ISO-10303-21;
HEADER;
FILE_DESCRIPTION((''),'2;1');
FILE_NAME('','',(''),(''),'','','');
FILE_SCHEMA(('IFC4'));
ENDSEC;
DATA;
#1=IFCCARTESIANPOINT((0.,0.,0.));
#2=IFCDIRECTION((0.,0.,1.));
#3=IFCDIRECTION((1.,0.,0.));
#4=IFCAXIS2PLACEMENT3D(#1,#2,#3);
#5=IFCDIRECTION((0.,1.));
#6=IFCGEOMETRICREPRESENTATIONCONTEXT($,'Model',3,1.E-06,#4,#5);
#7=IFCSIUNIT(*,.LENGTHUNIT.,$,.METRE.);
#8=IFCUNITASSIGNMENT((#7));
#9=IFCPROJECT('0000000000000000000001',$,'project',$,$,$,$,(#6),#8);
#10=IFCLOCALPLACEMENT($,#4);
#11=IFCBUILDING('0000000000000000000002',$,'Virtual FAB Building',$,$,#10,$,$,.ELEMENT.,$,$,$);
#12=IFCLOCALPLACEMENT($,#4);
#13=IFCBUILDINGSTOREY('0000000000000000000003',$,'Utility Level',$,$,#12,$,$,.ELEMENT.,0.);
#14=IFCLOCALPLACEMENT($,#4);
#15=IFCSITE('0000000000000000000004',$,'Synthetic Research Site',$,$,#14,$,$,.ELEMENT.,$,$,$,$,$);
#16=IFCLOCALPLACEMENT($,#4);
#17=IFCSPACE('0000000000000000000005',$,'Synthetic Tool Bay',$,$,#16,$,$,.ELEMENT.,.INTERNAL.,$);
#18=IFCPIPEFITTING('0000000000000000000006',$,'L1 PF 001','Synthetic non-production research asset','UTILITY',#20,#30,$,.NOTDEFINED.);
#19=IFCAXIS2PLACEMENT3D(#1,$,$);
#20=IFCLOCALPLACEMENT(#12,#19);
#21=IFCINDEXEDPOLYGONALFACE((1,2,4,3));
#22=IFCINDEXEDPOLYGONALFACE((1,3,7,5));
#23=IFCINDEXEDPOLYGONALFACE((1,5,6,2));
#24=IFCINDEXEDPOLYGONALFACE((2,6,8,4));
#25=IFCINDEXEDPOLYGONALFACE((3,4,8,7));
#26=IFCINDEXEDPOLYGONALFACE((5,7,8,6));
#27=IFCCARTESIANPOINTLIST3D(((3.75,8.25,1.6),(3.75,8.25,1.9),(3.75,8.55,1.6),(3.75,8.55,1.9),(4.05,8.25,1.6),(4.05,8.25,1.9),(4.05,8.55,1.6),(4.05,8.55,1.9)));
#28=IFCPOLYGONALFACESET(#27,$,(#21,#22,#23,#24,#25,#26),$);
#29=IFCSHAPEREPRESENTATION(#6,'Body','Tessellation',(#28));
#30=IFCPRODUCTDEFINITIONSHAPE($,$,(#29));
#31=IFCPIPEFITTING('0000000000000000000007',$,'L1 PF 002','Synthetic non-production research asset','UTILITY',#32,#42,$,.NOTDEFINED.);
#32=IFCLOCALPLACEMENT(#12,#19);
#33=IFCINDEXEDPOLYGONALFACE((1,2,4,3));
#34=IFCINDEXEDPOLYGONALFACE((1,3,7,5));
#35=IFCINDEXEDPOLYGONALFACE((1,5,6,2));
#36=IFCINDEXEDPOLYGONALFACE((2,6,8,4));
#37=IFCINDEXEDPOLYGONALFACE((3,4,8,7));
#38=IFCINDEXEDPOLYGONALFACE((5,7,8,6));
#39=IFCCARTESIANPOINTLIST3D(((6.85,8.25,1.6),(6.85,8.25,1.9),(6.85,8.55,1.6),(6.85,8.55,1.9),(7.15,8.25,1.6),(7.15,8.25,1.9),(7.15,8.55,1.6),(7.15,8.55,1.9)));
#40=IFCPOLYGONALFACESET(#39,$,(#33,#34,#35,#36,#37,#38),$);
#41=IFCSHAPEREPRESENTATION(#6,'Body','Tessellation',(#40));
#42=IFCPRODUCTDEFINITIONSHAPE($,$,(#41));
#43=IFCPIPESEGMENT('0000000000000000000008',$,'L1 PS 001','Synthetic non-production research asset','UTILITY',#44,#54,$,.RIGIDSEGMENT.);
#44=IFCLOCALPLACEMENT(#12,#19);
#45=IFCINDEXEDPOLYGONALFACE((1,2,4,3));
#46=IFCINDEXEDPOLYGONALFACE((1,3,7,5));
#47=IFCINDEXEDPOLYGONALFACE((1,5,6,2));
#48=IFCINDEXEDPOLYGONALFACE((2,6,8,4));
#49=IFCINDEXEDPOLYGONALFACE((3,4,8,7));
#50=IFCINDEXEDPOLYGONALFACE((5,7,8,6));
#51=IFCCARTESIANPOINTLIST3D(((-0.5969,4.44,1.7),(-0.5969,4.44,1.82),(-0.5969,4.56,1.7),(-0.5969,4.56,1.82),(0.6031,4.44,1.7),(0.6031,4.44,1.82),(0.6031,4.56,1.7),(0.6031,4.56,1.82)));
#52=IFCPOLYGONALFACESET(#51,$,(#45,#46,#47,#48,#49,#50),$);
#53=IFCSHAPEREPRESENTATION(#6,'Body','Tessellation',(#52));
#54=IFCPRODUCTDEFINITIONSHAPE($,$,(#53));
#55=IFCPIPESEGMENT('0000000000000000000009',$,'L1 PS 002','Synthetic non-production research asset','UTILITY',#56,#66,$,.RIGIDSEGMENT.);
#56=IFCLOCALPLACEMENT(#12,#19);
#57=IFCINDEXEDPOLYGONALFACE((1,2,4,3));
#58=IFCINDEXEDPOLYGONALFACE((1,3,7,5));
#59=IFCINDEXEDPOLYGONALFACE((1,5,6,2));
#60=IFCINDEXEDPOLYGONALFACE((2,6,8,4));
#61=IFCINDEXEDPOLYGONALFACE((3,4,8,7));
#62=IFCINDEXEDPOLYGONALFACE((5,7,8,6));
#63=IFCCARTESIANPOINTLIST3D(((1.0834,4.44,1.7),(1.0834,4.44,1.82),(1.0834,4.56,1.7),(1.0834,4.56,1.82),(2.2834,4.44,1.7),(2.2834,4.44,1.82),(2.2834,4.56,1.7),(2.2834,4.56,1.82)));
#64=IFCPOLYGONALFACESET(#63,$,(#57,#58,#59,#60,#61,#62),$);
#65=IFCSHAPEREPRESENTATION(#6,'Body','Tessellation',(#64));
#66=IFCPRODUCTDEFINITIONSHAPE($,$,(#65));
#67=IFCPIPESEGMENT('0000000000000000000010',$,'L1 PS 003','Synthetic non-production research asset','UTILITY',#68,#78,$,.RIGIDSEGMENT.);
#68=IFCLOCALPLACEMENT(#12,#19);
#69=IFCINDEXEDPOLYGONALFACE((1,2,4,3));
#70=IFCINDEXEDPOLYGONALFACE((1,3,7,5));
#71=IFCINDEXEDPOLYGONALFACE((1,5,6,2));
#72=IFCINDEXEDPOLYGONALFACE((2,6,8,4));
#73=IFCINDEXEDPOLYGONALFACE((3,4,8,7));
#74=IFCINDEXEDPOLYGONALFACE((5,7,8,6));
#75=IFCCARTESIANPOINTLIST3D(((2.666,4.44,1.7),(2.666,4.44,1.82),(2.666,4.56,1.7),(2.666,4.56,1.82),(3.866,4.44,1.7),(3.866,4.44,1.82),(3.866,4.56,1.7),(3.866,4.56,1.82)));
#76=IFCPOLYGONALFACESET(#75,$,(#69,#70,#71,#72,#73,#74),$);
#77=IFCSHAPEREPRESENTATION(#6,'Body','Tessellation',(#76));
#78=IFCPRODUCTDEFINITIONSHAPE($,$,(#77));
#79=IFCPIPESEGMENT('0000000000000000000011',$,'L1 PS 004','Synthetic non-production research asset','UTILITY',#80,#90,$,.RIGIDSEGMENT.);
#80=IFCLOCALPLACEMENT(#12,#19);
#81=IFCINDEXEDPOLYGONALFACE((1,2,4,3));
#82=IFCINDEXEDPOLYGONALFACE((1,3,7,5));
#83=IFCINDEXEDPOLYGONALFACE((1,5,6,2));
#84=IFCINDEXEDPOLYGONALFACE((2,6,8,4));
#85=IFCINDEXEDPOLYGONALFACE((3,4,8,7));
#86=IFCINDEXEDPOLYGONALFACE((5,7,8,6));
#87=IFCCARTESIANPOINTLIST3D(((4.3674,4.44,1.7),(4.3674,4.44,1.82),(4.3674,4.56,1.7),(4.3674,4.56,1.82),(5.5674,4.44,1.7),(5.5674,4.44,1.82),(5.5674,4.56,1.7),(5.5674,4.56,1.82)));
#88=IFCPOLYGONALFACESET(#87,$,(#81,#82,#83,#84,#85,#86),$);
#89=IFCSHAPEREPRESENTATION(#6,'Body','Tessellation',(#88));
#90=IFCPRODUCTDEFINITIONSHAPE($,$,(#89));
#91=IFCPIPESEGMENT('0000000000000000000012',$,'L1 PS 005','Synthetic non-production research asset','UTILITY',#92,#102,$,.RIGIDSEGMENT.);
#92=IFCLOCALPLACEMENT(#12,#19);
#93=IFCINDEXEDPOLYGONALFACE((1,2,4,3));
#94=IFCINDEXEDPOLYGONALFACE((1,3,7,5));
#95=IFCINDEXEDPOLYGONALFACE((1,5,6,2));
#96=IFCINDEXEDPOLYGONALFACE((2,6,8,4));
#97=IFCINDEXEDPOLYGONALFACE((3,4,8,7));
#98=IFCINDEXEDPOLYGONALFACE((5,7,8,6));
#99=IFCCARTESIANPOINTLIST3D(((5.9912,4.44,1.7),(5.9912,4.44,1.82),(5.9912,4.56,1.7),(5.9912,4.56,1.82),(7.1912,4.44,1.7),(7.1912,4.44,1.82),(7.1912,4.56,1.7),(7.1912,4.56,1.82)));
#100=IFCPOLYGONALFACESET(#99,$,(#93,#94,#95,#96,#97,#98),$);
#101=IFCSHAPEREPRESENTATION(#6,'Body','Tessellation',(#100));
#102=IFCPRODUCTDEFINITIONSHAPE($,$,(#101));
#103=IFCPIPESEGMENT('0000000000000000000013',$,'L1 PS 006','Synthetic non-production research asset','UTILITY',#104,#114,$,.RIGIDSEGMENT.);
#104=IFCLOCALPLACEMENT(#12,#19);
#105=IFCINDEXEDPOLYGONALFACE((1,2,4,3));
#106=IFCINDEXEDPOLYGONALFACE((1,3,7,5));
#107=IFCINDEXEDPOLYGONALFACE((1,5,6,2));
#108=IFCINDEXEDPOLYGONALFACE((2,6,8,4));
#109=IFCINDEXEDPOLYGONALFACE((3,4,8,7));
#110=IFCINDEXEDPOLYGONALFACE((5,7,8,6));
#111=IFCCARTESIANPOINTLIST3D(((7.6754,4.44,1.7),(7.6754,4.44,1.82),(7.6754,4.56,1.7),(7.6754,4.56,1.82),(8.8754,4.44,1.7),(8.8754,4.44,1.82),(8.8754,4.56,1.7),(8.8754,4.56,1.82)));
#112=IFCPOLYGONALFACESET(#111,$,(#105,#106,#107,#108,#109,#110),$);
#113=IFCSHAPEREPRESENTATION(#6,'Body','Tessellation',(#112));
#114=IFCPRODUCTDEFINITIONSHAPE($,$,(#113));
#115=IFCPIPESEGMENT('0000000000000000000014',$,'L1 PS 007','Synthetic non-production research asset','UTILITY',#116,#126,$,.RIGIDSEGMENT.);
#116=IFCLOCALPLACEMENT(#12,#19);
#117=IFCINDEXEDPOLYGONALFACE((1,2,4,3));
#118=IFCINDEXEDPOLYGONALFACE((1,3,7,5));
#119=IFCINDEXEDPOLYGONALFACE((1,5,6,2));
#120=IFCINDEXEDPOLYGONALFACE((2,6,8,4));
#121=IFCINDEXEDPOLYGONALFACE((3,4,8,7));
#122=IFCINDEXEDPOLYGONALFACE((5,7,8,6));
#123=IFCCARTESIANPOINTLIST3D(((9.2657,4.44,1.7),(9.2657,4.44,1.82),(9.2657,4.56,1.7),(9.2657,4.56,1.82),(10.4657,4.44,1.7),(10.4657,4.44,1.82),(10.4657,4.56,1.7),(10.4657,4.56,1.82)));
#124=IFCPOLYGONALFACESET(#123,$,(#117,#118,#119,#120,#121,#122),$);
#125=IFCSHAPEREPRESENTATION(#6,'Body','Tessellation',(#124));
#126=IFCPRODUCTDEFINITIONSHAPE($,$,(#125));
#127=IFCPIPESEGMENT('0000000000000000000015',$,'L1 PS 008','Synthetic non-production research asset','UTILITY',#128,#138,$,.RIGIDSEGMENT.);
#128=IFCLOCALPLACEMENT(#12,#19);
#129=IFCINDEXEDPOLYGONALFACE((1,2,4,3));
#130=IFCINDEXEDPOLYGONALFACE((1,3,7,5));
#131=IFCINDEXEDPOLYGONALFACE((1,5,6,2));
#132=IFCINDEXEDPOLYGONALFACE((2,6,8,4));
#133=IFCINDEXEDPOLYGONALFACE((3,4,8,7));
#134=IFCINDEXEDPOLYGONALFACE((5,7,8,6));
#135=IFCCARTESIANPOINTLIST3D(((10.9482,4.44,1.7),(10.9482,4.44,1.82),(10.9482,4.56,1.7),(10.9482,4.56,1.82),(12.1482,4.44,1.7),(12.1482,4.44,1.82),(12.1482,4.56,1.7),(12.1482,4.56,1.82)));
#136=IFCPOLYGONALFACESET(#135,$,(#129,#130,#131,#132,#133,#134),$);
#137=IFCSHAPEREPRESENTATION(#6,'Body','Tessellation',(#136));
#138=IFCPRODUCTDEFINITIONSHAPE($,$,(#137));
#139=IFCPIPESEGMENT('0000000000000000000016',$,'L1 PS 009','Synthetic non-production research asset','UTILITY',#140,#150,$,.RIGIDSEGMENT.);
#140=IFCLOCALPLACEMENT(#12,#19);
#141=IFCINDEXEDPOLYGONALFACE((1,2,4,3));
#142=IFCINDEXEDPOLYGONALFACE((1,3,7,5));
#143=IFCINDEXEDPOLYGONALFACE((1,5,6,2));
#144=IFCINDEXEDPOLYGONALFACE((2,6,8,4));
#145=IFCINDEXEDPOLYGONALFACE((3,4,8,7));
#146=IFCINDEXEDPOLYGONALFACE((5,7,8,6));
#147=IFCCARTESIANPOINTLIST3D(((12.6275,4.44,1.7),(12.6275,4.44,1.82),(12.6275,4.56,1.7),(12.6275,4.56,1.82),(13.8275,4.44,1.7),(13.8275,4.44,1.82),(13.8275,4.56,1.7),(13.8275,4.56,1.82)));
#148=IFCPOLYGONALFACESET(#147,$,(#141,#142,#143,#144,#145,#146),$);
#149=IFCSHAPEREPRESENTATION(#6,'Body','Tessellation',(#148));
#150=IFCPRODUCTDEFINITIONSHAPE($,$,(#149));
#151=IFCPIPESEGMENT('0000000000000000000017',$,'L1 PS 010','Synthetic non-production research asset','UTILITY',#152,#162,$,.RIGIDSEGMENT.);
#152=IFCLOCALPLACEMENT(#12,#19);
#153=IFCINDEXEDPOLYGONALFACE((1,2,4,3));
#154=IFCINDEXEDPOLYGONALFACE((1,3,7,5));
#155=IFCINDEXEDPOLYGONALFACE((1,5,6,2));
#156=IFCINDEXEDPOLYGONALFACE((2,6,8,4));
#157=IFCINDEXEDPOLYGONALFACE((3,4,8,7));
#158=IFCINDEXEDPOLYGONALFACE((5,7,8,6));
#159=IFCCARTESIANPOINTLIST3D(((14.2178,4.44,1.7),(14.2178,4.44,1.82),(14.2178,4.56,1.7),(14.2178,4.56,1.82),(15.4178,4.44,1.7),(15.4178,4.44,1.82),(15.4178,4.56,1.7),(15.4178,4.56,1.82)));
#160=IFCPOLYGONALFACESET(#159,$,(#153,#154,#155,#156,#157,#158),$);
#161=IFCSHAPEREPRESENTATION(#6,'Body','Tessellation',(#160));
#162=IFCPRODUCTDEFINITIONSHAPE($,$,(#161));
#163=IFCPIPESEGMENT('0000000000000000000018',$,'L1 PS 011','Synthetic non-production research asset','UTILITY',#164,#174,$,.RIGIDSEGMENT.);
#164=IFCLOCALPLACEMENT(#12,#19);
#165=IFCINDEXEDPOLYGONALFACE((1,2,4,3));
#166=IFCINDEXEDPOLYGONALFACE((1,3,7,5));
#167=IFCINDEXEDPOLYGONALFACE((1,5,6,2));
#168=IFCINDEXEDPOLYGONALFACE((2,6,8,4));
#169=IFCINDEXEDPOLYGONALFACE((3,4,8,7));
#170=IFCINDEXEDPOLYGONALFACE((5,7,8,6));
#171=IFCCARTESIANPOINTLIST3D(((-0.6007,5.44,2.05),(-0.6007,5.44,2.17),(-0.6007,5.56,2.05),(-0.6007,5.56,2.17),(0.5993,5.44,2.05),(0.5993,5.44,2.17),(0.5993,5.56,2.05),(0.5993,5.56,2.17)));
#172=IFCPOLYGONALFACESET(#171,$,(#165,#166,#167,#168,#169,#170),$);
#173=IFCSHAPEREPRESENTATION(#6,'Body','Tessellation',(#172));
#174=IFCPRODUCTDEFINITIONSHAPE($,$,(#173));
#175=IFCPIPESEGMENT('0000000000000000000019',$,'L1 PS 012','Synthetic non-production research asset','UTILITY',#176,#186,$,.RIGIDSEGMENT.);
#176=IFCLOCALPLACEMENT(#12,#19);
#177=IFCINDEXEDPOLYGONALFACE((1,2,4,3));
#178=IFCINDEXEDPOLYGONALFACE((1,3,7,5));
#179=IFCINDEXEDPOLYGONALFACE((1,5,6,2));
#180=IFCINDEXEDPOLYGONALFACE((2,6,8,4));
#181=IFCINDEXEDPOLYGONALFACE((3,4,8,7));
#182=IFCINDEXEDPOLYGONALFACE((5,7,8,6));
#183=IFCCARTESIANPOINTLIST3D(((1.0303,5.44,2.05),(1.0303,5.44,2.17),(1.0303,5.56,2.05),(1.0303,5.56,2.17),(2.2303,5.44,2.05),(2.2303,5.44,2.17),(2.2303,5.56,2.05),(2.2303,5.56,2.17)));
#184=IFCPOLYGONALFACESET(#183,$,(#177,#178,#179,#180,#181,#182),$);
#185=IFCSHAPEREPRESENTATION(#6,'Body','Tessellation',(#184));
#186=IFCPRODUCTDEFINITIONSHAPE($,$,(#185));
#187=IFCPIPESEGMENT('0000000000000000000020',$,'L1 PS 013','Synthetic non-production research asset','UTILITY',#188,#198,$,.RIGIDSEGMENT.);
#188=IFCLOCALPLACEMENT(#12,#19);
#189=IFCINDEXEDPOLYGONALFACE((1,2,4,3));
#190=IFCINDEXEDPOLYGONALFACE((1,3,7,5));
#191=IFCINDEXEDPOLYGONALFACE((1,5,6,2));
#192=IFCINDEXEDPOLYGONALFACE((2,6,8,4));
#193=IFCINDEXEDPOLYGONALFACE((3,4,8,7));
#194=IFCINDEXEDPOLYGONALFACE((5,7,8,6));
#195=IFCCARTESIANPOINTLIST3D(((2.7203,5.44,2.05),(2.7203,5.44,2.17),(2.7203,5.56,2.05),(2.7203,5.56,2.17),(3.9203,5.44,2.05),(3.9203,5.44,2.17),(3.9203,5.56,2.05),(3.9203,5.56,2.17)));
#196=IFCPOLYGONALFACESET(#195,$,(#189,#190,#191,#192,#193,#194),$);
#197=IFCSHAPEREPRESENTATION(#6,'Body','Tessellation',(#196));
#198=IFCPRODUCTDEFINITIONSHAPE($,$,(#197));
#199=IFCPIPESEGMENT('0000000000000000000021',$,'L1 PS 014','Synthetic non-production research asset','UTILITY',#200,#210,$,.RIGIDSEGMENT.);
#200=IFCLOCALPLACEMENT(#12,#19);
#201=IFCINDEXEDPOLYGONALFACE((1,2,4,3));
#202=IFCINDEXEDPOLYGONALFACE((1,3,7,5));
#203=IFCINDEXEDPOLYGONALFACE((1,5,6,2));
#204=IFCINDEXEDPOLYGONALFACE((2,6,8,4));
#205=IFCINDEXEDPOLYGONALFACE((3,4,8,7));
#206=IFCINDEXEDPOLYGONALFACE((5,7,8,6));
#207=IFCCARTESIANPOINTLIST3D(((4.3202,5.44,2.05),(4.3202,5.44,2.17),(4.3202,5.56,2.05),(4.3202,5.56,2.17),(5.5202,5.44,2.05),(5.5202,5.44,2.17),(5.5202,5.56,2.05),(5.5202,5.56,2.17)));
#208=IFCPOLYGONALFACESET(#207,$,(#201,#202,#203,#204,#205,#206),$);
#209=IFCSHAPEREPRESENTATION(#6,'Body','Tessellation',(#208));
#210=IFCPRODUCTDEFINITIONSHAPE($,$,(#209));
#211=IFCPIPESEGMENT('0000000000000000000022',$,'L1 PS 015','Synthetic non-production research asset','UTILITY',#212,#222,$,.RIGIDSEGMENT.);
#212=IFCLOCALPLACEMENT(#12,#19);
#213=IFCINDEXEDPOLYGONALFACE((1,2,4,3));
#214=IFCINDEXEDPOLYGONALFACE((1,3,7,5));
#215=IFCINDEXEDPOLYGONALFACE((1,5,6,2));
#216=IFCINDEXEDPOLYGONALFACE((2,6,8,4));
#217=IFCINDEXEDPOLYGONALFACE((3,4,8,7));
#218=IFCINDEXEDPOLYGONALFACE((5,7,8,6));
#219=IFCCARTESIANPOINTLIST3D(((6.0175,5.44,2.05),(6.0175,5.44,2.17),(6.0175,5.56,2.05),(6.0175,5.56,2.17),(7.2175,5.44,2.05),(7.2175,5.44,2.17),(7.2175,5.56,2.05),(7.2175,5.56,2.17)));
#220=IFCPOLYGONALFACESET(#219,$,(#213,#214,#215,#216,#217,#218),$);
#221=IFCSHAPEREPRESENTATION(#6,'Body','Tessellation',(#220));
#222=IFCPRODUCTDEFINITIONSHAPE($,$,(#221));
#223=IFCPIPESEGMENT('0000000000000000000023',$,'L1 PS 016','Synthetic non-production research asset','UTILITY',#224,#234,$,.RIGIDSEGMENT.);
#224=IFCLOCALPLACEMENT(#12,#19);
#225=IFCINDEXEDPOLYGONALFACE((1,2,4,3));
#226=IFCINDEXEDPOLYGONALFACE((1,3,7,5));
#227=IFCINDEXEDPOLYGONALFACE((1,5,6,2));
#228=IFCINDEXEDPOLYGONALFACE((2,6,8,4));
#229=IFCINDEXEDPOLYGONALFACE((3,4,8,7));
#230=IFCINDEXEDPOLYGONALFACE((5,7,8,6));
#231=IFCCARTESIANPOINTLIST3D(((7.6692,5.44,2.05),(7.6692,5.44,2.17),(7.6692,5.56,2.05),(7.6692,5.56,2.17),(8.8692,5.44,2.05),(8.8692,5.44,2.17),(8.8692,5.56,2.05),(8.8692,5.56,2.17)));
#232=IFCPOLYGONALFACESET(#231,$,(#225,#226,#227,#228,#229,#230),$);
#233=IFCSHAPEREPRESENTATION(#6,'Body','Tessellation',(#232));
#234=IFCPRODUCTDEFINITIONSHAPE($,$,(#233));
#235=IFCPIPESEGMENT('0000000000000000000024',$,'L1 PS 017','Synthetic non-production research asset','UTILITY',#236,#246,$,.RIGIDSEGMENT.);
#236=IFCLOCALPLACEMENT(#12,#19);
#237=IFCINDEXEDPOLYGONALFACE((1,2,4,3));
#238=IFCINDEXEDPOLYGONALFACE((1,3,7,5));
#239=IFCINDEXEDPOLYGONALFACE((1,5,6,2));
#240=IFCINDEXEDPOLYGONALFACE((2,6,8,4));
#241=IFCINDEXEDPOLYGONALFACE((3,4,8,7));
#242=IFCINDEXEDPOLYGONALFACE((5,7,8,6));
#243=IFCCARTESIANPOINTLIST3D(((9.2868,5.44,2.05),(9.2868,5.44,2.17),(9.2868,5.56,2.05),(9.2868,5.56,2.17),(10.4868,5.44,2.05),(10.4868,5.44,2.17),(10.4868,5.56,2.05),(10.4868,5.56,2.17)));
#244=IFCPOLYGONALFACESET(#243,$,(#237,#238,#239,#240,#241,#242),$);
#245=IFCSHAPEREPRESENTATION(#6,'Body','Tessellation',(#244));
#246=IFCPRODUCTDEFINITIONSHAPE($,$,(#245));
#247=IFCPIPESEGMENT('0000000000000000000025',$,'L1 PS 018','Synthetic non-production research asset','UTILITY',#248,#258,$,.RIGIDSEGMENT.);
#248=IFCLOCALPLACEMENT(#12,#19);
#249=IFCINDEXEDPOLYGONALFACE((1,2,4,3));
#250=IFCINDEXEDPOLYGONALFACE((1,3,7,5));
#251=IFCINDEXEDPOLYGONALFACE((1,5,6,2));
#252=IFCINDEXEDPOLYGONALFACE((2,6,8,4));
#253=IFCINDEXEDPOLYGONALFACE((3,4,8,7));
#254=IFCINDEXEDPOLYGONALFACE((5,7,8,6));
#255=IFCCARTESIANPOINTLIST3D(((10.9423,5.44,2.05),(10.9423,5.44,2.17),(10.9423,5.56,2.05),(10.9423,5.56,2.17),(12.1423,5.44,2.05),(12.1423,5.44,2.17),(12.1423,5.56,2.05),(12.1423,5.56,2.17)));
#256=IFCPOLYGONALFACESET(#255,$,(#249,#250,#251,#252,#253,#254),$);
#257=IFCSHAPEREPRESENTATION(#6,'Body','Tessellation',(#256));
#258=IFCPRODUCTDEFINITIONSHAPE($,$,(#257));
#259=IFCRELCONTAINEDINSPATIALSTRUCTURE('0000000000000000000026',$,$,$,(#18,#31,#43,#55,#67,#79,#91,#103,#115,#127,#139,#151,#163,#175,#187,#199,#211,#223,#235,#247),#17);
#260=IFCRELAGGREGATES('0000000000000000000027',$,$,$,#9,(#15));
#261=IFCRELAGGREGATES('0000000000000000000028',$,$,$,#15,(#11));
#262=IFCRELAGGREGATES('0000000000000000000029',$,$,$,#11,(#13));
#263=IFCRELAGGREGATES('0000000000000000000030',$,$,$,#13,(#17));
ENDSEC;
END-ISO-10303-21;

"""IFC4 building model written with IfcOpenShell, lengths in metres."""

from ifc_helpers import new_model, si_unit, direction, frame, origin_with_axes, origin_2d_with_axis, place, context, project, spatial, rectangle, extrude, element, save


model = new_model("IFC4")

# Units and contexts
model_context = context("Model", 3, precision=1e-06, world=origin_with_axes(), true_north=direction((0.0, 1.0)))
ifc_project = project(units=[si_unit("LENGTHUNIT", "METRE")], contexts=[model_context])

# Site, building, storey, space
site_placement = place(None, origin_with_axes())
site = spatial("IfcSite", under=ifc_project, at=site_placement, Name="Synthetic Research Site", CompositionType="ELEMENT")
building_placement = place(None, origin_with_axes())
building = spatial("IfcBuilding", under=site, at=building_placement, Name="Virtual FAB Building", CompositionType="ELEMENT")
storey_placement = place(None, origin_with_axes())
storey = spatial("IfcBuildingStorey", under=building, at=storey_placement, Name="Utility Level", CompositionType="ELEMENT", Elevation=0.0)
space_placement = place(None, origin_with_axes())
space = spatial("IfcSpace", under=storey, at=space_placement, Name="Synthetic Tool Bay", CompositionType="ELEMENT", PredefinedType="INTERNAL")

# Pipe fittings
for number, where, z_axis, x_axis, name in (
    (1, (3.9, 8.4, 1.6), (0.0, 0.0, 1.0), (1.0, 0.0, 0.0), "L1 PF 001"),
    (2, (7.0, 8.4, 1.6), (0.0, 0.0, 1.0), (1.0, 0.0, 0.0), "L1 PF 002"),
):
    element("IfcPipeFitting", number, at=place(None, frame(where, z_axis=z_axis, x_axis=x_axis)), inside=space, Name=name, Description="Synthetic non-production research asset", ObjectType="UTILITY", PredefinedType="NOTDEFINED", context=model_context, shape_type="SweptSolid", body=[
        extrude(rectangle(XDim=0.3, YDim=0.3, at=origin_2d_with_axis()), origin_with_axes(), (0.0, 0.0, 1.0), 0.3),
    ])

# Pipe segments
for number, where, z_axis, x_axis, name in (
    (3, (0.0031, 4.5, 1.7), (0.0, 0.0, 1.0), (1.0, 0.0, 0.0), "L1 PS 001"),
    (4, (1.6834, 4.5, 1.7), (0.0, 0.0, 1.0), (1.0, 0.0, 0.0), "L1 PS 002"),
    (5, (3.266, 4.5, 1.7), (0.0, 0.0, 1.0), (1.0, 0.0, 0.0), "L1 PS 003"),
    (6, (4.9674, 4.5, 1.7), (0.0, 0.0, 1.0), (1.0, 0.0, 0.0), "L1 PS 004"),
    (7, (6.5912, 4.5, 1.7), (0.0, 0.0, 1.0), (1.0, 0.0, 0.0), "L1 PS 005"),
    (8, (8.2754, 4.5, 1.7), (0.0, 0.0, 1.0), (1.0, 0.0, 0.0), "L1 PS 006"),
    (9, (9.8657, 4.5, 1.7), (0.0, 0.0, 1.0), (1.0, 0.0, 0.0), "L1 PS 007"),
    (10, (11.5482, 4.5, 1.7), (0.0, 0.0, 1.0), (1.0, 0.0, 0.0), "L1 PS 008"),
    (11, (13.2275, 4.5, 1.7), (0.0, 0.0, 1.0), (1.0, 0.0, 0.0), "L1 PS 009"),
    (12, (14.8178, 4.5, 1.7), (0.0, 0.0, 1.0), (1.0, 0.0, 0.0), "L1 PS 010"),
    (13, (-0.0007, 5.5, 2.05), (0.0, 0.0, 1.0), (1.0, 0.0, 0.0), "L1 PS 011"),
    (14, (1.6303, 5.5, 2.05), (0.0, 0.0, 1.0), (1.0, 0.0, 0.0), "L1 PS 012"),
    (15, (3.3203, 5.5, 2.05), (0.0, 0.0, 1.0), (1.0, 0.0, 0.0), "L1 PS 013"),
    (16, (4.9202, 5.5, 2.05), (0.0, 0.0, 1.0), (1.0, 0.0, 0.0), "L1 PS 014"),
    (17, (6.6175, 5.5, 2.05), (0.0, 0.0, 1.0), (1.0, 0.0, 0.0), "L1 PS 015"),
    (18, (8.2692, 5.5, 2.05), (0.0, 0.0, 1.0), (1.0, 0.0, 0.0), "L1 PS 016"),
    (19, (9.8868, 5.5, 2.05), (0.0, 0.0, 1.0), (1.0, 0.0, 0.0), "L1 PS 017"),
    (20, (11.5423, 5.5, 2.05), (0.0, 0.0, 1.0), (1.0, 0.0, 0.0), "L1 PS 018"),
):
    element("IfcPipeSegment", number, at=place(None, frame(where, z_axis=z_axis, x_axis=x_axis)), inside=space, Name=name, Description="Synthetic non-production research asset", ObjectType="UTILITY", PredefinedType="RIGIDSEGMENT", context=model_context, shape_type="SweptSolid", body=[
        extrude(rectangle(XDim=1.2, YDim=0.12, at=origin_2d_with_axis()), origin_with_axes(), (0.0, 0.0, 1.0), 0.12),
    ])

save(model, "model.ifc")
